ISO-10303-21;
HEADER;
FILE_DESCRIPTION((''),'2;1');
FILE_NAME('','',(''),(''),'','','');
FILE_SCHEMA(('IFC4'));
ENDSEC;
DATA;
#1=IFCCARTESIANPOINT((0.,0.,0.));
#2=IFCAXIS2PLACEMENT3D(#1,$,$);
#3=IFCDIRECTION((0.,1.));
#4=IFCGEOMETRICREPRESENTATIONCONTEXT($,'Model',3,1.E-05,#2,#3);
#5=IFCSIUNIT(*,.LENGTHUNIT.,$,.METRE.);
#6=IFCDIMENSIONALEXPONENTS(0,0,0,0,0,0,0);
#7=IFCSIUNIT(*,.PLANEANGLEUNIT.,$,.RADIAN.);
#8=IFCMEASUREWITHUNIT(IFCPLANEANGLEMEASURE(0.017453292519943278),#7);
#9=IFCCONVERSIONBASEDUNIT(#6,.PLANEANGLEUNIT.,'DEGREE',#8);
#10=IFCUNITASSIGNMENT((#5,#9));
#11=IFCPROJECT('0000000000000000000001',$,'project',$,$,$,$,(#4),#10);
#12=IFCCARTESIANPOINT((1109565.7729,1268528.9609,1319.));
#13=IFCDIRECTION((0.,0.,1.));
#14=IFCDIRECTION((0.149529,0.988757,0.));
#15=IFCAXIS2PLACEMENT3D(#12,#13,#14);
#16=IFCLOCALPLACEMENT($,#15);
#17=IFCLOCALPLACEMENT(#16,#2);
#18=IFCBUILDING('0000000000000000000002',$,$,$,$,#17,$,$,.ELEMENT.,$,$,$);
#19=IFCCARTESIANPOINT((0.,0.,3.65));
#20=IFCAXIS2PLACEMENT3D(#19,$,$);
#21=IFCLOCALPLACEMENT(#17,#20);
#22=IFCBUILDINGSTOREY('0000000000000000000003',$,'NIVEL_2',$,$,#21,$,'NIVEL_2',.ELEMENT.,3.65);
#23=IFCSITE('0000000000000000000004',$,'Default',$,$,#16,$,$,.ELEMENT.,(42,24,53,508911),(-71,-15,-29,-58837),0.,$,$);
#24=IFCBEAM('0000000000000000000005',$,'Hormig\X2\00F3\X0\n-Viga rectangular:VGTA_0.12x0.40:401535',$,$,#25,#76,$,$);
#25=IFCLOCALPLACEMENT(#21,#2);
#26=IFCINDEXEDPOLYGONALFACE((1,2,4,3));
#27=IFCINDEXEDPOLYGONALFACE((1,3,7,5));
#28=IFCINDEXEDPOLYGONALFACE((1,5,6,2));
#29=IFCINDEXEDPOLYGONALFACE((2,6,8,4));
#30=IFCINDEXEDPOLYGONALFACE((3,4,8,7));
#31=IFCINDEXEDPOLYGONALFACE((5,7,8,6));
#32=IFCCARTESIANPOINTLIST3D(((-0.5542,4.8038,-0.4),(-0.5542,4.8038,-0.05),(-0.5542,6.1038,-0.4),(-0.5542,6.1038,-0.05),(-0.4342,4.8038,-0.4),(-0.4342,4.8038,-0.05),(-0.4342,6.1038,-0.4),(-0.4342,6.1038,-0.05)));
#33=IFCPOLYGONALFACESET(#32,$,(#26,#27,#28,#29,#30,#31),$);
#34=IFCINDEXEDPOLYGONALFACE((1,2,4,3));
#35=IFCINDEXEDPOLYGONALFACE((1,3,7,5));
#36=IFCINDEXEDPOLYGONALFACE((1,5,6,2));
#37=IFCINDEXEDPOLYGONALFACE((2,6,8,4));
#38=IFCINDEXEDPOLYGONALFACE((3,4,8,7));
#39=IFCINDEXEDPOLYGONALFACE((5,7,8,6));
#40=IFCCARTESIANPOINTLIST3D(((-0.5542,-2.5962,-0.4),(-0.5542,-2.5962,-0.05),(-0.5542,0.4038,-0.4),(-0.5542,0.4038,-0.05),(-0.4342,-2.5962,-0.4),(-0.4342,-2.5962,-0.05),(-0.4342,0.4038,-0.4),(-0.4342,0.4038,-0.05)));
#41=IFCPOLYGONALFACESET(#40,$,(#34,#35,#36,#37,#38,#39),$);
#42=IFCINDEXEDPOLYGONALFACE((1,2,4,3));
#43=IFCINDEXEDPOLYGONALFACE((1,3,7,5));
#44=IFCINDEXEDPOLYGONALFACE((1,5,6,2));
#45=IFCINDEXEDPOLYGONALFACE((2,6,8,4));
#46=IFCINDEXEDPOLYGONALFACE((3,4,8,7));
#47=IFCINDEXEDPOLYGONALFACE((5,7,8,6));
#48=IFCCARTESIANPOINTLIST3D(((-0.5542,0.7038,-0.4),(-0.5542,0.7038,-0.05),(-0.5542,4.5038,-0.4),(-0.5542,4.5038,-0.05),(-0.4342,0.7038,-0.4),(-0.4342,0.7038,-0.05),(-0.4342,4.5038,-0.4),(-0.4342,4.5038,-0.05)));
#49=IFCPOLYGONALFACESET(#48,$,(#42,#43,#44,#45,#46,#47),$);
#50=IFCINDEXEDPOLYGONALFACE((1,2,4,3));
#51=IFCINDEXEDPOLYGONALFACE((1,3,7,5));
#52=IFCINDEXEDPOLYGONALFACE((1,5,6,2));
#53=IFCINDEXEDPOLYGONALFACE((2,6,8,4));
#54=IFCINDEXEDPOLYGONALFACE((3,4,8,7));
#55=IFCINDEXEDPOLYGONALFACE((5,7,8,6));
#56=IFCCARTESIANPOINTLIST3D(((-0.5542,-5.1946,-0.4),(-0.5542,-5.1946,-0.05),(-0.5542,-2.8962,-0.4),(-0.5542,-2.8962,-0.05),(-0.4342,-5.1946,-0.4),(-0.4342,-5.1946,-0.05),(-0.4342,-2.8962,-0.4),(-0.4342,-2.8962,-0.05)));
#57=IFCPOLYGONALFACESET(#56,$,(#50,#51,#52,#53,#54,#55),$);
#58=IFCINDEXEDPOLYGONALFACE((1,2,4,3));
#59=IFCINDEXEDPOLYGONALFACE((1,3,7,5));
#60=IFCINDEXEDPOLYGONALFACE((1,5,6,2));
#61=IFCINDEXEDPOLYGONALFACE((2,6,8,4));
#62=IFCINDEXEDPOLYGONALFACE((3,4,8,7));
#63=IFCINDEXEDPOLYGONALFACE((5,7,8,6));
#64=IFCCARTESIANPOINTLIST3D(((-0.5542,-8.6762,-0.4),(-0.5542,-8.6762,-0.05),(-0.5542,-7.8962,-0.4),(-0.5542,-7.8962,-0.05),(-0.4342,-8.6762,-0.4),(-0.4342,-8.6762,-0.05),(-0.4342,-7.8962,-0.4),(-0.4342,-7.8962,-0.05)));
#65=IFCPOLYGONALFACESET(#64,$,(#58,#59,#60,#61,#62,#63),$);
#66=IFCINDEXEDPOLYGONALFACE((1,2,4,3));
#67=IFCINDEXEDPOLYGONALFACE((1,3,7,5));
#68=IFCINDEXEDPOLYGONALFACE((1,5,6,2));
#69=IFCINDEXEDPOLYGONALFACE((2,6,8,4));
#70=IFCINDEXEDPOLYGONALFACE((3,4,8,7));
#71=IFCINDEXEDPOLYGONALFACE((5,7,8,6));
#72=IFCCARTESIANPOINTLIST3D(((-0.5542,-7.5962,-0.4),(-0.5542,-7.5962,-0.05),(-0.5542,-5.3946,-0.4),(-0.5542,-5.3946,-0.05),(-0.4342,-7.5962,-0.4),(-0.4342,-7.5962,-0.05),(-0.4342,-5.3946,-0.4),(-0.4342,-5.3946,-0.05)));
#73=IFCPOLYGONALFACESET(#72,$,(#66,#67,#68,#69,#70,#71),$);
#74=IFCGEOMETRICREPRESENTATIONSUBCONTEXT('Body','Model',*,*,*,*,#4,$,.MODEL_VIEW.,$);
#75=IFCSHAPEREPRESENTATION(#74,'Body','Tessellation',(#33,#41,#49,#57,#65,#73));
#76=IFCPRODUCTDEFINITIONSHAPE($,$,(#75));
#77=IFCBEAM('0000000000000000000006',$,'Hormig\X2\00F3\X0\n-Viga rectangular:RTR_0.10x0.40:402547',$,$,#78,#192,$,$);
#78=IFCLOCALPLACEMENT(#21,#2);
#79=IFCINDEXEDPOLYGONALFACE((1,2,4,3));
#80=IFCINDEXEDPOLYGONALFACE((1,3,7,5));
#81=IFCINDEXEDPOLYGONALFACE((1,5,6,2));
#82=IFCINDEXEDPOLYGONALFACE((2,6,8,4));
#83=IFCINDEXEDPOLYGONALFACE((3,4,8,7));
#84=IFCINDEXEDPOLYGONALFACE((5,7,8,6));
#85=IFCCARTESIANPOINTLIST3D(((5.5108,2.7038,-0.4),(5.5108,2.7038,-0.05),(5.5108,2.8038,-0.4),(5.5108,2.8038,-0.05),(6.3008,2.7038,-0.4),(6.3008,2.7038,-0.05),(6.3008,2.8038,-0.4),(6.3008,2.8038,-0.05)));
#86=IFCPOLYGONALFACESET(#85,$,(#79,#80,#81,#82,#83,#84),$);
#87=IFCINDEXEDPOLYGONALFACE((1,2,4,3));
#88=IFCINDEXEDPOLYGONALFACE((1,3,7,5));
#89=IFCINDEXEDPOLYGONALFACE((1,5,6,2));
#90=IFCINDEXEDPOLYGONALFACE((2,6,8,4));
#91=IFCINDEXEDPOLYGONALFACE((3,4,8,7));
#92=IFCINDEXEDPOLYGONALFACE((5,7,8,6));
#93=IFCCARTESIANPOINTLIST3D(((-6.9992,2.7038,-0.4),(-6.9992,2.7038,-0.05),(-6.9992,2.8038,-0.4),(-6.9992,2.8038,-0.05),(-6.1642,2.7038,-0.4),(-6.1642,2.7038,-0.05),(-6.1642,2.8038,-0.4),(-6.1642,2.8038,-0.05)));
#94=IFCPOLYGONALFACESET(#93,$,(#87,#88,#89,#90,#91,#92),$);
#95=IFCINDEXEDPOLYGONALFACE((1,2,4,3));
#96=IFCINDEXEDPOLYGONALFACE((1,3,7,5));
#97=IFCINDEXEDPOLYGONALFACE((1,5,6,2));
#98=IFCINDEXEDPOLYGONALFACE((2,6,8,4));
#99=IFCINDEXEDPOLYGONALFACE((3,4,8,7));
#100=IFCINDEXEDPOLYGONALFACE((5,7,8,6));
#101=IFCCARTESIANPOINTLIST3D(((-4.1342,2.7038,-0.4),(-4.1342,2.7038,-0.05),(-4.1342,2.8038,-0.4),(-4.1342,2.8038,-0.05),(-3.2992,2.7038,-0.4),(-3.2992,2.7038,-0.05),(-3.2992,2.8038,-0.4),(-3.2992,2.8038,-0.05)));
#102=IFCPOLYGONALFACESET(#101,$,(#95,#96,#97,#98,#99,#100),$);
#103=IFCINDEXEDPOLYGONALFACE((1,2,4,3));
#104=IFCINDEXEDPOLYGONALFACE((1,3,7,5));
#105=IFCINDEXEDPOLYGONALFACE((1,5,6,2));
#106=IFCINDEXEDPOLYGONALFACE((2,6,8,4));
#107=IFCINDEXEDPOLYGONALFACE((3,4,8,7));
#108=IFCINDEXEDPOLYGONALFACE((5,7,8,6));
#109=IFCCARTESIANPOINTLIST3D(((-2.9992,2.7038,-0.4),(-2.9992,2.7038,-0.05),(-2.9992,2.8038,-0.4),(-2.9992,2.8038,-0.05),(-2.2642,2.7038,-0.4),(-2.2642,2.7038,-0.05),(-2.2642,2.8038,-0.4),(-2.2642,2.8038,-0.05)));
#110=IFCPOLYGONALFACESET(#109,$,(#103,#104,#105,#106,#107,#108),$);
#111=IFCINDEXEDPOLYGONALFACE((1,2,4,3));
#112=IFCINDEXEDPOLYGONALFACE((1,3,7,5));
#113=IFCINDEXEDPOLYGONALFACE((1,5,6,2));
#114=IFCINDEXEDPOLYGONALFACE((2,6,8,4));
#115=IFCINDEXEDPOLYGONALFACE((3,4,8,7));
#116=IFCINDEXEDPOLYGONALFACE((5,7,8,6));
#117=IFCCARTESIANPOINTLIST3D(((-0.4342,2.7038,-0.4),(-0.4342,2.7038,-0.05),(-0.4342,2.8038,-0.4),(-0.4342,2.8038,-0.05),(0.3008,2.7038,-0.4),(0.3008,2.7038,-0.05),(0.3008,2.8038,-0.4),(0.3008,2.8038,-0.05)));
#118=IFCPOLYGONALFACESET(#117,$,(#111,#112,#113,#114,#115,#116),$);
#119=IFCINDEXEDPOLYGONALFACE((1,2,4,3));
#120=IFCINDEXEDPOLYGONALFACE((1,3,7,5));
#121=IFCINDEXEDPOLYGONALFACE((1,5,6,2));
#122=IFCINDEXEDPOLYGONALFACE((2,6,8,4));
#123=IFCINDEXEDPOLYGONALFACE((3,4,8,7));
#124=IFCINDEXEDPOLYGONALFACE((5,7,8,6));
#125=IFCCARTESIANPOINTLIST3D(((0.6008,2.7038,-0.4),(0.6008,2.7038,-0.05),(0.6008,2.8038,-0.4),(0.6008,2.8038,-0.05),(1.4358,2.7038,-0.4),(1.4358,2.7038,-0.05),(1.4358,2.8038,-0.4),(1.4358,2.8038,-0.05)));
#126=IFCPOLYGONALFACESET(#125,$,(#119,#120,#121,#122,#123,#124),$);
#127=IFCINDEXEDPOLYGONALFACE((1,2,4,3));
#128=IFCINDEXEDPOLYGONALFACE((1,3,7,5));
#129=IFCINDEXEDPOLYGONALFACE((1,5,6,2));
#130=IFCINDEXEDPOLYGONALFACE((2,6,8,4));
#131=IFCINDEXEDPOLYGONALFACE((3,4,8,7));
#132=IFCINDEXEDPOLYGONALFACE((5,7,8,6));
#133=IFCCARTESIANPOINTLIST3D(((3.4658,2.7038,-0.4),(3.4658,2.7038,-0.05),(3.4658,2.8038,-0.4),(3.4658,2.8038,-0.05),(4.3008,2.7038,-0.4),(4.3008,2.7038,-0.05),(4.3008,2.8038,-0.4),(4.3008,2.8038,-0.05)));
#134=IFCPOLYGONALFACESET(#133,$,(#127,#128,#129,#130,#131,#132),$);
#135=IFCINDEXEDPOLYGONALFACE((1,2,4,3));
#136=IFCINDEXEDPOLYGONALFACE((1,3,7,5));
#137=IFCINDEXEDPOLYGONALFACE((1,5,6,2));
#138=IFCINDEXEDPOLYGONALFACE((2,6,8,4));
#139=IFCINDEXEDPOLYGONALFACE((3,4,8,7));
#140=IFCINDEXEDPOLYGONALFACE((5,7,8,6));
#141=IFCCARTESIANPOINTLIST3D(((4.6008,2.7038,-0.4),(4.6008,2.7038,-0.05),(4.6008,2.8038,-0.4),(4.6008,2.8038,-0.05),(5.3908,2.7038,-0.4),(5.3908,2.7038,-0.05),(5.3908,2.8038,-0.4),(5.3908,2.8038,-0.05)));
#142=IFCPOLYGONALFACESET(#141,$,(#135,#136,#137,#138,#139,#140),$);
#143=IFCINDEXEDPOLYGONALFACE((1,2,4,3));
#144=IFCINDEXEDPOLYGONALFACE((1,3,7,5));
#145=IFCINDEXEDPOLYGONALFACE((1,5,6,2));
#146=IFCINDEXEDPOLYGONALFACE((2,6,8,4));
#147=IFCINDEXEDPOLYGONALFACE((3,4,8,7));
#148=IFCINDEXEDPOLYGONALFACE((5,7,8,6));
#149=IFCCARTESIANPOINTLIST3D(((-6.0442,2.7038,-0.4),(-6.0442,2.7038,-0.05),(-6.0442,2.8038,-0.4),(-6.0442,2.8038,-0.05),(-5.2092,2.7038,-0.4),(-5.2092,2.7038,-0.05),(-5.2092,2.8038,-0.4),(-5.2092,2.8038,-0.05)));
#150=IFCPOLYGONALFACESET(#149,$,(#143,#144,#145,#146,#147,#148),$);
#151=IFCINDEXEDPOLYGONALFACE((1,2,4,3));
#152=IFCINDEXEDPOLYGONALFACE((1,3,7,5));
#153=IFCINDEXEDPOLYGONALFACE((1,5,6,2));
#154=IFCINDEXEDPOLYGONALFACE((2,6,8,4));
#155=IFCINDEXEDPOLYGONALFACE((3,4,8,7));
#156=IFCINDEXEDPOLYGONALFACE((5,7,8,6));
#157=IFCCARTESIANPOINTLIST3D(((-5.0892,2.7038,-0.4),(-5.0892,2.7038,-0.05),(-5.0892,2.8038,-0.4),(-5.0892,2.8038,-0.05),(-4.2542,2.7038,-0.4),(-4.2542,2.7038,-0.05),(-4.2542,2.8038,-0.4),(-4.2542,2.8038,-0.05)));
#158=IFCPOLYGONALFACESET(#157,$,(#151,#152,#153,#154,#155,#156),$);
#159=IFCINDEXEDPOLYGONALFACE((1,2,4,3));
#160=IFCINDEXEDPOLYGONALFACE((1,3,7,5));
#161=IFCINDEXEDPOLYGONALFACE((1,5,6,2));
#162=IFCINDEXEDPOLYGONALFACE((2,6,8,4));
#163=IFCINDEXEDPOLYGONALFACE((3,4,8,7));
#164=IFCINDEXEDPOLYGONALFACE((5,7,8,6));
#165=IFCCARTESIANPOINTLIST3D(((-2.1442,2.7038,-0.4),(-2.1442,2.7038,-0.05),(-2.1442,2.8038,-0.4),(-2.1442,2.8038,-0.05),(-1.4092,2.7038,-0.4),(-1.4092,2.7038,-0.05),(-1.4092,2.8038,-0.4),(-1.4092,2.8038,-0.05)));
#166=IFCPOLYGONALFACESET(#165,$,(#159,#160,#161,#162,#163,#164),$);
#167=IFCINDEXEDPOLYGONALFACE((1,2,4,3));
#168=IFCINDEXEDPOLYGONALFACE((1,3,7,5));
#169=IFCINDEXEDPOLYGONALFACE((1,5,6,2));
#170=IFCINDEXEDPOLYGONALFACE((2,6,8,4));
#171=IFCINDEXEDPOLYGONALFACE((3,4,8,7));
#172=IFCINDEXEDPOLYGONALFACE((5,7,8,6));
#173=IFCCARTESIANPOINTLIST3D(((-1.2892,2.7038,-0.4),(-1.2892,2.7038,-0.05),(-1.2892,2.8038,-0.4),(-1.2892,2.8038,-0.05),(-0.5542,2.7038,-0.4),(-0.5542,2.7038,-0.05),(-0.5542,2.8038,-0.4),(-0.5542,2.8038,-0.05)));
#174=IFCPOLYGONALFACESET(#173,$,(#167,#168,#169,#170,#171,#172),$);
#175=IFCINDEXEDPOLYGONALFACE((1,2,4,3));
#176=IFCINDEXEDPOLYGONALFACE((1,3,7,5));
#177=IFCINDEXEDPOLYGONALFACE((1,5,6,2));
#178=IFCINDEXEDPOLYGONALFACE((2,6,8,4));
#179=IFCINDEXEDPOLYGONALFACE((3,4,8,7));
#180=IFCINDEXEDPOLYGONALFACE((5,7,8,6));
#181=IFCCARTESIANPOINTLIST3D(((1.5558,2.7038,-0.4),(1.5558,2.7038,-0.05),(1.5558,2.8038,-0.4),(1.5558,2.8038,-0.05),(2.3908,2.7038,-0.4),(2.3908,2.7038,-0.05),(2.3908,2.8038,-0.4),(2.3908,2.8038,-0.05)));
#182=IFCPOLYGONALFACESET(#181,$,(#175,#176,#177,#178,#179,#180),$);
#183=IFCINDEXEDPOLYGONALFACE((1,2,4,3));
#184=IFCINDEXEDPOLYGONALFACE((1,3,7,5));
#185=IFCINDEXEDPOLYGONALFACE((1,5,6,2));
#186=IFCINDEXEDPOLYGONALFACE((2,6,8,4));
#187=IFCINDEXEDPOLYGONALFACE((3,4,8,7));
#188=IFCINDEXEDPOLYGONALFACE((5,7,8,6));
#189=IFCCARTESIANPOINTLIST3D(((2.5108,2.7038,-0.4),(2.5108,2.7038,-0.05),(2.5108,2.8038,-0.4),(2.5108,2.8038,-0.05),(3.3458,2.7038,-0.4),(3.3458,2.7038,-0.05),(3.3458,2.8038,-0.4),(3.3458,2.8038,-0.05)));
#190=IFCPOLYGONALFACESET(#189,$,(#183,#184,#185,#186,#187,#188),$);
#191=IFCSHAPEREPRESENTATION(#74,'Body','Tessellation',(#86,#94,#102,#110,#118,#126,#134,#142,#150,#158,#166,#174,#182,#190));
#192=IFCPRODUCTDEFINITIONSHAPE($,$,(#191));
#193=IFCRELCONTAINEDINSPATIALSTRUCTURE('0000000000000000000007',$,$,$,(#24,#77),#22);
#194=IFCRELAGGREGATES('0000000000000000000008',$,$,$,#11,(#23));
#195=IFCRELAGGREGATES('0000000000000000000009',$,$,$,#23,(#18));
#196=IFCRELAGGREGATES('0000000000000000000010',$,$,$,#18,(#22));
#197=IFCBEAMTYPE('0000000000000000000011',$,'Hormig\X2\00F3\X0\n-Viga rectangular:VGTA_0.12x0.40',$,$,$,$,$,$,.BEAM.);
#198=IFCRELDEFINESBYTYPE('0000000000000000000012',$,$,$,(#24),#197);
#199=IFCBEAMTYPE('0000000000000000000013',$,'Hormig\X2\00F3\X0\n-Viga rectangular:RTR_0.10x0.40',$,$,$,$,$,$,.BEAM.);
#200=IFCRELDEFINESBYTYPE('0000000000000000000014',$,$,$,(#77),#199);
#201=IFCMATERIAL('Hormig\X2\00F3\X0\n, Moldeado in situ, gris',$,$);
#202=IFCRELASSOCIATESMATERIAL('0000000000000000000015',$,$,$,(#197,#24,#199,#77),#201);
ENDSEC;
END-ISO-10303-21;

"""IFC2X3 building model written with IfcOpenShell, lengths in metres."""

from ifc_helpers import new_model, entity, si_unit, converted_unit, direction, frame, frame_2d, origin, origin_2d_with_axis, place, context, subcontext, project, spatial, rectangle, extrude, source, transform, mapped, material, type_object, type_shapes, element, save


model = new_model("IFC2X3")

# Units and contexts
model_context = context("Model", 3, precision=1e-05, world=origin(), true_north=direction((0.0, 1.0)))
body_context = subcontext(model_context, "Body", "Model", "MODEL_VIEW")
ifc_project = project(units=[si_unit("LENGTHUNIT", "METRE"), converted_unit("PLANEANGLEUNIT", "DEGREE", entity("IfcPlaneAngleMeasure", 0.017453292519943278), si_unit("PLANEANGLEUNIT", "RADIAN"), dimensions=[0, 0, 0, 0, 0, 0, 0])], contexts=[model_context])

# Site, building, storey
site_placement = place(None, frame((1109565.7729, 1268528.9609, 1319.0), z_axis=(0.0, 0.0, 1.0), x_axis=(0.149529, 0.988757, 0.0)))
site = spatial("IfcSite", under=ifc_project, at=site_placement, Name="Default", CompositionType="ELEMENT", RefLatitude=(42, 24, 53, 508911), RefLongitude=(-71, -15, -29, -58837), RefElevation=0.0)
building_placement = place(site_placement, origin())
building = spatial("IfcBuilding", under=site, at=building_placement, CompositionType="ELEMENT")
storey_placement = place(building_placement, frame((0.0, 0.0, 3.65)))
storey = spatial("IfcBuildingStorey", under=building, at=storey_placement, Name="NIVEL_2", LongName="NIVEL_2", CompositionType="ELEMENT", Elevation=3.65)

# Shared definitions
ifc_material_1 = material(Name="Hormigón, Moldeado in situ, gris")

# Beams
beam_type_1 = type_object("IfcBeamType", Name="Hormigón-Viga rectangular:VGTA_0.12x0.40", PredefinedType="BEAM", material=ifc_material_1)
shared_shape_1 = source(origin(), body_context, "Body", "SweptSolid", [
    extrude(rectangle(XDim=0.35, YDim=0.12, at=frame_2d((0.0, 0.0), x_axis=(0.0, 1.0))), frame((-0.4942, 4.8038, 3.425), z_axis=(0.0, 1.0, 0.0), x_axis=(-1.0, 0.0, 0.0)), (0.0, 0.0, 1.0), 1.3),
    extrude(rectangle(XDim=0.35, YDim=0.12, at=frame_2d((0.0, 0.0), x_axis=(0.0, 1.0))), frame((-0.4942, -2.5962, 3.425), z_axis=(0.0, 1.0, 0.0), x_axis=(-1.0, 0.0, 0.0)), (0.0, 0.0, 1.0), 3.0),
    extrude(rectangle(XDim=0.35, YDim=0.12, at=frame_2d((0.0, 0.0), x_axis=(0.0, 1.0))), frame((-0.4942, 0.7038, 3.425), z_axis=(0.0, 1.0, 0.0), x_axis=(-1.0, 0.0, 0.0)), (0.0, 0.0, 1.0), 3.8),
    extrude(rectangle(XDim=0.35, YDim=0.12, at=frame_2d((0.0, 0.0), x_axis=(0.0, 1.0))), frame((-0.4942, -5.1946, 3.425), z_axis=(0.0, 1.0, 0.0), x_axis=(-1.0, 0.0, 0.0)), (0.0, 0.0, 1.0), 2.2984),
    extrude(rectangle(XDim=0.35, YDim=0.12, at=frame_2d((0.0, 0.0), x_axis=(0.0, 1.0))), frame((-0.4942, -8.6762, 3.425), z_axis=(0.0, 1.0, 0.0), x_axis=(-1.0, 0.0, 0.0)), (0.0, 0.0, 1.0), 0.78),
    extrude(rectangle(XDim=0.35, YDim=0.12, at=frame_2d((0.0, 0.0), x_axis=(0.0, 1.0))), frame((-0.4942, -7.5962, 3.425), z_axis=(0.0, 1.0, 0.0), x_axis=(-1.0, 0.0, 0.0)), (0.0, 0.0, 1.0), 2.2016),
])
type_shapes(beam_type_1, [shared_shape_1])
beam_1_placement = place(storey_placement, frame((0.0, 0.0, -3.65)))
element("IfcBeam", 1, at=beam_1_placement, inside=storey, type_object=beam_type_1, material=ifc_material_1, Name="Hormigón-Viga rectangular:VGTA_0.12x0.40:401535", context=body_context, shape_type="MappedRepresentation", body=[
    mapped(shared_shape_1, transform((0.0, 0.0, 0.0), scale=1.0)),
])
beam_type_2 = type_object("IfcBeamType", Name="Hormigón-Viga rectangular:RTR_0.10x0.40", PredefinedType="BEAM", material=ifc_material_1)
shared_shape_2 = source(origin(), body_context, "Body", "SweptSolid", [
    extrude(rectangle(XDim=0.35, YDim=0.1, at=origin_2d_with_axis()), frame((5.5108, 2.7538, 3.425), z_axis=(1.0, 0.0, 0.0), x_axis=(0.0, 0.0, -1.0)), (0.0, 0.0, 1.0), 0.79),
    extrude(rectangle(XDim=0.35, YDim=0.1, at=origin_2d_with_axis()), frame((-6.9992, 2.7538, 3.425), z_axis=(1.0, 0.0, 0.0), x_axis=(0.0, 0.0, -1.0)), (0.0, 0.0, 1.0), 0.835),
    extrude(rectangle(XDim=0.35, YDim=0.1, at=origin_2d_with_axis()), frame((-4.1342, 2.7538, 3.425), z_axis=(1.0, 0.0, 0.0), x_axis=(0.0, 0.0, -1.0)), (0.0, 0.0, 1.0), 0.835),
    extrude(rectangle(XDim=0.35, YDim=0.1, at=frame_2d((0.0, 0.0), x_axis=(1.0, 0.0))), frame((-2.9992, 2.7538, 3.425), z_axis=(1.0, 0.0, 0.0), x_axis=(0.0, 0.0, -1.0)), (0.0, 0.0, 1.0), 0.735),
    extrude(rectangle(XDim=0.35, YDim=0.1, at=frame_2d((0.0, 0.0), x_axis=(1.0, 0.0))), frame((-0.4342, 2.7538, 3.425), z_axis=(1.0, 0.0, 0.0), x_axis=(0.0, 0.0, -1.0)), (0.0, 0.0, 1.0), 0.735),
    extrude(rectangle(XDim=0.35, YDim=0.1, at=frame_2d((0.0, 0.0), x_axis=(1.0, 0.0))), frame((0.6008, 2.7538, 3.425), z_axis=(1.0, 0.0, 0.0), x_axis=(0.0, 0.0, -1.0)), (0.0, 0.0, 1.0), 0.835),
    extrude(rectangle(XDim=0.35, YDim=0.1, at=frame_2d((0.0, 0.0), x_axis=(1.0, 0.0))), frame((3.4658, 2.7538, 3.425), z_axis=(1.0, 0.0, 0.0), x_axis=(0.0, 0.0, -1.0)), (0.0, 0.0, 1.0), 0.835),
    extrude(rectangle(XDim=0.35, YDim=0.1, at=origin_2d_with_axis()), frame((4.6008, 2.7538, 3.425), z_axis=(1.0, 0.0, 0.0), x_axis=(0.0, 0.0, -1.0)), (0.0, 0.0, 1.0), 0.79),
    extrude(rectangle(XDim=0.35, YDim=0.1, at=frame_2d((0.0, 0.0), x_axis=(1.0, 0.0))), frame((-6.0442, 2.7538, 3.425), z_axis=(1.0, 0.0, 0.0), x_axis=(0.0, 0.0, -1.0)), (0.0, 0.0, 1.0), 0.835),
    extrude(rectangle(XDim=0.35, YDim=0.1, at=frame_2d((0.0, 0.0), x_axis=(1.0, 0.0))), frame((-5.0892, 2.7538, 3.425), z_axis=(1.0, 0.0, 0.0), x_axis=(0.0, 0.0, -1.0)), (0.0, 0.0, 1.0), 0.835),
    extrude(rectangle(XDim=0.35, YDim=0.1, at=frame_2d((0.0, 0.0), x_axis=(1.0, 0.0))), frame((-2.1442, 2.7538, 3.425), z_axis=(1.0, 0.0, 0.0), x_axis=(0.0, 0.0, -1.0)), (0.0, 0.0, 1.0), 0.735),
    extrude(rectangle(XDim=0.35, YDim=0.1, at=frame_2d((0.0, 0.0), x_axis=(1.0, 0.0))), frame((-1.2892, 2.7538, 3.425), z_axis=(1.0, 0.0, 0.0), x_axis=(0.0, 0.0, -1.0)), (0.0, 0.0, 1.0), 0.735),
    extrude(rectangle(XDim=0.35, YDim=0.1, at=origin_2d_with_axis()), frame((1.5558, 2.7538, 3.425), z_axis=(1.0, 0.0, 0.0), x_axis=(0.0, 0.0, -1.0)), (0.0, 0.0, 1.0), 0.835),
    extrude(rectangle(XDim=0.35, YDim=0.1, at=origin_2d_with_axis()), frame((2.5108, 2.7538, 3.425), z_axis=(1.0, 0.0, 0.0), x_axis=(0.0, 0.0, -1.0)), (0.0, 0.0, 1.0), 0.835),
])
type_shapes(beam_type_2, [shared_shape_2])
beam_2_placement = place(storey_placement, frame((0.0, 0.0, -3.65)))
element("IfcBeam", 2, at=beam_2_placement, inside=storey, type_object=beam_type_2, material=ifc_material_1, Name="Hormigón-Viga rectangular:RTR_0.10x0.40:402547", context=body_context, shape_type="MappedRepresentation", body=[
    mapped(shared_shape_2, transform((0.0, 0.0, 0.0), scale=1.0)),
])

save(model, "model.ifc")
